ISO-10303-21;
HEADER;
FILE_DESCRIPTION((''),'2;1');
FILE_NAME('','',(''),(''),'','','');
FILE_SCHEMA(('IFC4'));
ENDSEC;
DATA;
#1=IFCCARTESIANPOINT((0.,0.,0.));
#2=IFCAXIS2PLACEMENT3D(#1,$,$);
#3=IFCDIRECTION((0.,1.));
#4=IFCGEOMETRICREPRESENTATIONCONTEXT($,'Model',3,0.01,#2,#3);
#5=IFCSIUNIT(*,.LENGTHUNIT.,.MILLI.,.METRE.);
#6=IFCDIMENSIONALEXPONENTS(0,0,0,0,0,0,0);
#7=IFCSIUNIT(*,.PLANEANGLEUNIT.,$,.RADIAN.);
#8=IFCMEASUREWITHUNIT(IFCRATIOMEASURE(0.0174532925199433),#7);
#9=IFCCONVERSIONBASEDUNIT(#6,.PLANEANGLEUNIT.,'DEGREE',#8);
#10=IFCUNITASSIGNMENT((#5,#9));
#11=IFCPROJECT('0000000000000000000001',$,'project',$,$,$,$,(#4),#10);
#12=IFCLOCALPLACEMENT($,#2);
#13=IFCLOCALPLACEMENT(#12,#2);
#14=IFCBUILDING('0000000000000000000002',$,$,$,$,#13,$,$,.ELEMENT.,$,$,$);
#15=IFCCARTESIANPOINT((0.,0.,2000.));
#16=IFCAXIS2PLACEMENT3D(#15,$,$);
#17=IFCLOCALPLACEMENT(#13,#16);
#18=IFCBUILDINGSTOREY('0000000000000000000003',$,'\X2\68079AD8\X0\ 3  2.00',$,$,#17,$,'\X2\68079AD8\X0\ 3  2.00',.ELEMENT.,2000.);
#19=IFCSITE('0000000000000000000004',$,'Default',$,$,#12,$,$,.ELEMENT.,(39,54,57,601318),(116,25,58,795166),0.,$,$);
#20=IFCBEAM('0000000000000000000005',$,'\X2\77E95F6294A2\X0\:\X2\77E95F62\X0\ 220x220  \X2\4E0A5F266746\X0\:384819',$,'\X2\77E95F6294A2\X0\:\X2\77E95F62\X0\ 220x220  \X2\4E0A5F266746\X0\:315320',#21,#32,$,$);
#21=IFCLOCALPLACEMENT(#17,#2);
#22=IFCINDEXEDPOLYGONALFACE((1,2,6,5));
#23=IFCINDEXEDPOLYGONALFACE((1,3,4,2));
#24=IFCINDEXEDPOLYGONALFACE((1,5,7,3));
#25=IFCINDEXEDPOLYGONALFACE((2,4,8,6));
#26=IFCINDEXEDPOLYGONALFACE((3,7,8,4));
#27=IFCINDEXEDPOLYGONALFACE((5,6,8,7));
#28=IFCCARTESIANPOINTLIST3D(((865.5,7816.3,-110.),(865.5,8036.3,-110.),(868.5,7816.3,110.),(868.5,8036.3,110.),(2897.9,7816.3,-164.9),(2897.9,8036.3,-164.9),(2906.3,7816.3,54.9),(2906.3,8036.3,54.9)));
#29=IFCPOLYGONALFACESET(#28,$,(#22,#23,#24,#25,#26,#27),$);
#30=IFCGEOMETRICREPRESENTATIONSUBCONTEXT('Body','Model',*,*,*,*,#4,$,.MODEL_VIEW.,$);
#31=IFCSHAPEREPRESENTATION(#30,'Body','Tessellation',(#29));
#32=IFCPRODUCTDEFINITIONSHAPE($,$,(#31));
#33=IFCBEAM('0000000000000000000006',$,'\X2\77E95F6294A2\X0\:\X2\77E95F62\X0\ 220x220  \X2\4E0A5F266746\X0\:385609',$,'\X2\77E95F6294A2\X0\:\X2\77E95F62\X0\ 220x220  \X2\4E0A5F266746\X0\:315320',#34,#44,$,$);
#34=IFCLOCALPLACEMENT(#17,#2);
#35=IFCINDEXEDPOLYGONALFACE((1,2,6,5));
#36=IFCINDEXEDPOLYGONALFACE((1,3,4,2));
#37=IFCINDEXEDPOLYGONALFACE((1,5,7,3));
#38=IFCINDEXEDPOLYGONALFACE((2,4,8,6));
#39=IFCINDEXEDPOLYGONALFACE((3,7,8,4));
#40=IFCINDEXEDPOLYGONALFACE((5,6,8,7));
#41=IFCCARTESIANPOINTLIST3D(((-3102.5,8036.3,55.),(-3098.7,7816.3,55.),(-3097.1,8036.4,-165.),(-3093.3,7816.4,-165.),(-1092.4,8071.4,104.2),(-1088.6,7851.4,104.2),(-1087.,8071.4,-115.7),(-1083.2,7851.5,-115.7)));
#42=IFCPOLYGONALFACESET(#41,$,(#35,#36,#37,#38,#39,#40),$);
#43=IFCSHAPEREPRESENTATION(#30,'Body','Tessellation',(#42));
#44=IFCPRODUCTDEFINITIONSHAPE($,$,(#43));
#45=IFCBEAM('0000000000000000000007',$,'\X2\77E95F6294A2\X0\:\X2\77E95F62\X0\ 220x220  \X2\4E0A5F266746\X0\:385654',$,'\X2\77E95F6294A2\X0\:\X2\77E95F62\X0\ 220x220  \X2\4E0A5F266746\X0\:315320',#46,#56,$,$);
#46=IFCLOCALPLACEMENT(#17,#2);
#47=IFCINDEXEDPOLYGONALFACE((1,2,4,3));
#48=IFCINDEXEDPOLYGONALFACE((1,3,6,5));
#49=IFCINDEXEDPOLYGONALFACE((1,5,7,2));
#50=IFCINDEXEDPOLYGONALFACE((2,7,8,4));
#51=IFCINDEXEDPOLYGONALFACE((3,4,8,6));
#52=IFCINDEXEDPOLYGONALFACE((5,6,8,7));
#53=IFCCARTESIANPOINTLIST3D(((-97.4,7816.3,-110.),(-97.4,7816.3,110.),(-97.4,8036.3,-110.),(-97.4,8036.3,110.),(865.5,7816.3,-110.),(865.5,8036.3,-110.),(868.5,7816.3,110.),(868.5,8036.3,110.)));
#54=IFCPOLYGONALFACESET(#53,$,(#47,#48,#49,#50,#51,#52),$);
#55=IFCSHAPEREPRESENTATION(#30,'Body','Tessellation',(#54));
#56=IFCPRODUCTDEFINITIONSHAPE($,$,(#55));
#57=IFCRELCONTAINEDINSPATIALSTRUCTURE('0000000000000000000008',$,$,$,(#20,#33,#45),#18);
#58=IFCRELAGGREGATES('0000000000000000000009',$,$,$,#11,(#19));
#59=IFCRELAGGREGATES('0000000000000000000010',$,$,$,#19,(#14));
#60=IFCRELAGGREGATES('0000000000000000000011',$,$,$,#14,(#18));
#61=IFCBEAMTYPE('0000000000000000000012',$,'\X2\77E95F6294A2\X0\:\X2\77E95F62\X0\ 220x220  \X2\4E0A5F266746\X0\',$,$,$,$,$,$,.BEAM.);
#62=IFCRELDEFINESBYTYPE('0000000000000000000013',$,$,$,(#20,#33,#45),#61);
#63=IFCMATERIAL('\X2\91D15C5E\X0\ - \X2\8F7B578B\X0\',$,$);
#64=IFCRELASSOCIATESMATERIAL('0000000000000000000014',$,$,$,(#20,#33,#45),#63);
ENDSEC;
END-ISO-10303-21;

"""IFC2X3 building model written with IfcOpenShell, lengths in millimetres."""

from ifc_helpers import new_model, entity, si_unit, converted_unit, direction, frame, frame_2d, origin, origin_2d_with_axis, place, context, subcontext, project, spatial, rectangle, extrude, clip, halfspace, material, type_object, element, save


model = new_model("IFC2X3")

# Units and contexts
model_context = context("Model", 3, precision=0.01, world=origin(), true_north=direction((0.0, 1.0)))
body_context = subcontext(model_context, "Body", "Model", "MODEL_VIEW")
ifc_project = project(units=[si_unit("LENGTHUNIT", "METRE", prefix="MILLI"), converted_unit("PLANEANGLEUNIT", "DEGREE", entity("IfcRatioMeasure", 0.0174532925199433), si_unit("PLANEANGLEUNIT", "RADIAN"), dimensions=[0, 0, 0, 0, 0, 0, 0])], contexts=[model_context])

# Site, building, storey
site_placement = place(None, origin())
site = spatial("IfcSite", under=ifc_project, at=site_placement, Name="Default", CompositionType="ELEMENT", RefLatitude=(39, 54, 57, 601318), RefLongitude=(116, 25, 58, 795166), RefElevation=0.0)
building_placement = place(site_placement, origin())
building = spatial("IfcBuilding", under=site, at=building_placement, CompositionType="ELEMENT")
storey_placement = place(building_placement, frame((0.0, 0.0, 2000.0)))
storey = spatial("IfcBuildingStorey", under=building, at=storey_placement, Name="标高 3  2.00", LongName="标高 3  2.00", CompositionType="ELEMENT", Elevation=2000.0)

# Beams
ifc_material = material(Name="金属 - 轻型")
beam_type = type_object("IfcBeamType", Name="矩形钢:矩形 220x220  上弦杆", PredefinedType="BEAM")
beam_1_placement = place(storey_placement, frame((867.0, 7926.3, 0.0), z_axis=(0.027016, 0.0, 0.999635), x_axis=(0.999635, 0.0, -0.027016)))
element("IfcBeam", 1, at=beam_1_placement, inside=storey, type_object=beam_type, material=ifc_material, Name="矩形钢:矩形 220x220  上弦杆:384819", ObjectType="矩形钢:矩形 220x220  上弦杆:315320", context=body_context, shape_type="Clipping", body=[
    clip(clip(extrude(rectangle(XDim=220.0, YDim=220.0, at=frame_2d((0.0, 0.0), x_axis=(1.0, 0.0))), frame((-1.5, 0.0, 0.0), z_axis=(1.0, 0.0, 0.0), x_axis=(0.0, 0.0, -1.0)), (0.0, 0.0, 1.0), 2038.6), halfspace(frame((2034.6, 0.0, -110.0), z_axis=(0.999937, 0.0, -0.01122), x_axis=(0.01122, 0.0, 0.999937)), False)), halfspace(frame((-1.5, 0.0, 110.0), z_axis=(-0.999909, 0.0, -0.013509), x_axis=(-0.013509, 0.0, 0.999909)), False)),
])
beam_2_placement = place(storey_placement, frame((-3097.9, 7926.3, -55.0), z_axis=(-0.024496, -0.000428, 0.9997), x_axis=(0.999548, 0.017447, 0.0245)))
element("IfcBeam", 2, at=beam_2_placement, inside=storey, type_object=beam_type, material=ifc_material, Name="矩形钢:矩形 220x220  上弦杆:385609", ObjectType="矩形钢:矩形 220x220  上弦杆:315320", context=body_context, shape_type="SweptSolid", body=[
    extrude(rectangle(XDim=220.0, YDim=220.0, at=origin_2d_with_axis()), frame((0.0, 0.0, 0.0), z_axis=(1.0, 0.0, 0.0), x_axis=(0.0, 0.0, -1.0)), (0.0, 0.0, 1.0), 2011.0),
])
beam_3_placement = place(storey_placement, frame((-97.9, 7926.3, 0.0)))
element("IfcBeam", 3, at=beam_3_placement, inside=storey, type_object=beam_type, material=ifc_material, Name="矩形钢:矩形 220x220  上弦杆:385654", ObjectType="矩形钢:矩形 220x220  上弦杆:315320", context=body_context, shape_type="Clipping", body=[
    clip(extrude(rectangle(XDim=220.0, YDim=220.0, at=frame_2d((0.0, 0.0), x_axis=(1.0, 0.0))), frame((0.4, 0.0, 0.0), z_axis=(1.0, 0.0, 0.0), x_axis=(0.0, 0.0, -1.0)), (0.0, 0.0, 1.0), 965.9), halfspace(frame((966.4, 0.0, 110.0), z_axis=(0.999909, 0.0, -0.013509), x_axis=(0.013509, 0.0, 0.999909)), False)),
])

save(model, "model.ifc")
